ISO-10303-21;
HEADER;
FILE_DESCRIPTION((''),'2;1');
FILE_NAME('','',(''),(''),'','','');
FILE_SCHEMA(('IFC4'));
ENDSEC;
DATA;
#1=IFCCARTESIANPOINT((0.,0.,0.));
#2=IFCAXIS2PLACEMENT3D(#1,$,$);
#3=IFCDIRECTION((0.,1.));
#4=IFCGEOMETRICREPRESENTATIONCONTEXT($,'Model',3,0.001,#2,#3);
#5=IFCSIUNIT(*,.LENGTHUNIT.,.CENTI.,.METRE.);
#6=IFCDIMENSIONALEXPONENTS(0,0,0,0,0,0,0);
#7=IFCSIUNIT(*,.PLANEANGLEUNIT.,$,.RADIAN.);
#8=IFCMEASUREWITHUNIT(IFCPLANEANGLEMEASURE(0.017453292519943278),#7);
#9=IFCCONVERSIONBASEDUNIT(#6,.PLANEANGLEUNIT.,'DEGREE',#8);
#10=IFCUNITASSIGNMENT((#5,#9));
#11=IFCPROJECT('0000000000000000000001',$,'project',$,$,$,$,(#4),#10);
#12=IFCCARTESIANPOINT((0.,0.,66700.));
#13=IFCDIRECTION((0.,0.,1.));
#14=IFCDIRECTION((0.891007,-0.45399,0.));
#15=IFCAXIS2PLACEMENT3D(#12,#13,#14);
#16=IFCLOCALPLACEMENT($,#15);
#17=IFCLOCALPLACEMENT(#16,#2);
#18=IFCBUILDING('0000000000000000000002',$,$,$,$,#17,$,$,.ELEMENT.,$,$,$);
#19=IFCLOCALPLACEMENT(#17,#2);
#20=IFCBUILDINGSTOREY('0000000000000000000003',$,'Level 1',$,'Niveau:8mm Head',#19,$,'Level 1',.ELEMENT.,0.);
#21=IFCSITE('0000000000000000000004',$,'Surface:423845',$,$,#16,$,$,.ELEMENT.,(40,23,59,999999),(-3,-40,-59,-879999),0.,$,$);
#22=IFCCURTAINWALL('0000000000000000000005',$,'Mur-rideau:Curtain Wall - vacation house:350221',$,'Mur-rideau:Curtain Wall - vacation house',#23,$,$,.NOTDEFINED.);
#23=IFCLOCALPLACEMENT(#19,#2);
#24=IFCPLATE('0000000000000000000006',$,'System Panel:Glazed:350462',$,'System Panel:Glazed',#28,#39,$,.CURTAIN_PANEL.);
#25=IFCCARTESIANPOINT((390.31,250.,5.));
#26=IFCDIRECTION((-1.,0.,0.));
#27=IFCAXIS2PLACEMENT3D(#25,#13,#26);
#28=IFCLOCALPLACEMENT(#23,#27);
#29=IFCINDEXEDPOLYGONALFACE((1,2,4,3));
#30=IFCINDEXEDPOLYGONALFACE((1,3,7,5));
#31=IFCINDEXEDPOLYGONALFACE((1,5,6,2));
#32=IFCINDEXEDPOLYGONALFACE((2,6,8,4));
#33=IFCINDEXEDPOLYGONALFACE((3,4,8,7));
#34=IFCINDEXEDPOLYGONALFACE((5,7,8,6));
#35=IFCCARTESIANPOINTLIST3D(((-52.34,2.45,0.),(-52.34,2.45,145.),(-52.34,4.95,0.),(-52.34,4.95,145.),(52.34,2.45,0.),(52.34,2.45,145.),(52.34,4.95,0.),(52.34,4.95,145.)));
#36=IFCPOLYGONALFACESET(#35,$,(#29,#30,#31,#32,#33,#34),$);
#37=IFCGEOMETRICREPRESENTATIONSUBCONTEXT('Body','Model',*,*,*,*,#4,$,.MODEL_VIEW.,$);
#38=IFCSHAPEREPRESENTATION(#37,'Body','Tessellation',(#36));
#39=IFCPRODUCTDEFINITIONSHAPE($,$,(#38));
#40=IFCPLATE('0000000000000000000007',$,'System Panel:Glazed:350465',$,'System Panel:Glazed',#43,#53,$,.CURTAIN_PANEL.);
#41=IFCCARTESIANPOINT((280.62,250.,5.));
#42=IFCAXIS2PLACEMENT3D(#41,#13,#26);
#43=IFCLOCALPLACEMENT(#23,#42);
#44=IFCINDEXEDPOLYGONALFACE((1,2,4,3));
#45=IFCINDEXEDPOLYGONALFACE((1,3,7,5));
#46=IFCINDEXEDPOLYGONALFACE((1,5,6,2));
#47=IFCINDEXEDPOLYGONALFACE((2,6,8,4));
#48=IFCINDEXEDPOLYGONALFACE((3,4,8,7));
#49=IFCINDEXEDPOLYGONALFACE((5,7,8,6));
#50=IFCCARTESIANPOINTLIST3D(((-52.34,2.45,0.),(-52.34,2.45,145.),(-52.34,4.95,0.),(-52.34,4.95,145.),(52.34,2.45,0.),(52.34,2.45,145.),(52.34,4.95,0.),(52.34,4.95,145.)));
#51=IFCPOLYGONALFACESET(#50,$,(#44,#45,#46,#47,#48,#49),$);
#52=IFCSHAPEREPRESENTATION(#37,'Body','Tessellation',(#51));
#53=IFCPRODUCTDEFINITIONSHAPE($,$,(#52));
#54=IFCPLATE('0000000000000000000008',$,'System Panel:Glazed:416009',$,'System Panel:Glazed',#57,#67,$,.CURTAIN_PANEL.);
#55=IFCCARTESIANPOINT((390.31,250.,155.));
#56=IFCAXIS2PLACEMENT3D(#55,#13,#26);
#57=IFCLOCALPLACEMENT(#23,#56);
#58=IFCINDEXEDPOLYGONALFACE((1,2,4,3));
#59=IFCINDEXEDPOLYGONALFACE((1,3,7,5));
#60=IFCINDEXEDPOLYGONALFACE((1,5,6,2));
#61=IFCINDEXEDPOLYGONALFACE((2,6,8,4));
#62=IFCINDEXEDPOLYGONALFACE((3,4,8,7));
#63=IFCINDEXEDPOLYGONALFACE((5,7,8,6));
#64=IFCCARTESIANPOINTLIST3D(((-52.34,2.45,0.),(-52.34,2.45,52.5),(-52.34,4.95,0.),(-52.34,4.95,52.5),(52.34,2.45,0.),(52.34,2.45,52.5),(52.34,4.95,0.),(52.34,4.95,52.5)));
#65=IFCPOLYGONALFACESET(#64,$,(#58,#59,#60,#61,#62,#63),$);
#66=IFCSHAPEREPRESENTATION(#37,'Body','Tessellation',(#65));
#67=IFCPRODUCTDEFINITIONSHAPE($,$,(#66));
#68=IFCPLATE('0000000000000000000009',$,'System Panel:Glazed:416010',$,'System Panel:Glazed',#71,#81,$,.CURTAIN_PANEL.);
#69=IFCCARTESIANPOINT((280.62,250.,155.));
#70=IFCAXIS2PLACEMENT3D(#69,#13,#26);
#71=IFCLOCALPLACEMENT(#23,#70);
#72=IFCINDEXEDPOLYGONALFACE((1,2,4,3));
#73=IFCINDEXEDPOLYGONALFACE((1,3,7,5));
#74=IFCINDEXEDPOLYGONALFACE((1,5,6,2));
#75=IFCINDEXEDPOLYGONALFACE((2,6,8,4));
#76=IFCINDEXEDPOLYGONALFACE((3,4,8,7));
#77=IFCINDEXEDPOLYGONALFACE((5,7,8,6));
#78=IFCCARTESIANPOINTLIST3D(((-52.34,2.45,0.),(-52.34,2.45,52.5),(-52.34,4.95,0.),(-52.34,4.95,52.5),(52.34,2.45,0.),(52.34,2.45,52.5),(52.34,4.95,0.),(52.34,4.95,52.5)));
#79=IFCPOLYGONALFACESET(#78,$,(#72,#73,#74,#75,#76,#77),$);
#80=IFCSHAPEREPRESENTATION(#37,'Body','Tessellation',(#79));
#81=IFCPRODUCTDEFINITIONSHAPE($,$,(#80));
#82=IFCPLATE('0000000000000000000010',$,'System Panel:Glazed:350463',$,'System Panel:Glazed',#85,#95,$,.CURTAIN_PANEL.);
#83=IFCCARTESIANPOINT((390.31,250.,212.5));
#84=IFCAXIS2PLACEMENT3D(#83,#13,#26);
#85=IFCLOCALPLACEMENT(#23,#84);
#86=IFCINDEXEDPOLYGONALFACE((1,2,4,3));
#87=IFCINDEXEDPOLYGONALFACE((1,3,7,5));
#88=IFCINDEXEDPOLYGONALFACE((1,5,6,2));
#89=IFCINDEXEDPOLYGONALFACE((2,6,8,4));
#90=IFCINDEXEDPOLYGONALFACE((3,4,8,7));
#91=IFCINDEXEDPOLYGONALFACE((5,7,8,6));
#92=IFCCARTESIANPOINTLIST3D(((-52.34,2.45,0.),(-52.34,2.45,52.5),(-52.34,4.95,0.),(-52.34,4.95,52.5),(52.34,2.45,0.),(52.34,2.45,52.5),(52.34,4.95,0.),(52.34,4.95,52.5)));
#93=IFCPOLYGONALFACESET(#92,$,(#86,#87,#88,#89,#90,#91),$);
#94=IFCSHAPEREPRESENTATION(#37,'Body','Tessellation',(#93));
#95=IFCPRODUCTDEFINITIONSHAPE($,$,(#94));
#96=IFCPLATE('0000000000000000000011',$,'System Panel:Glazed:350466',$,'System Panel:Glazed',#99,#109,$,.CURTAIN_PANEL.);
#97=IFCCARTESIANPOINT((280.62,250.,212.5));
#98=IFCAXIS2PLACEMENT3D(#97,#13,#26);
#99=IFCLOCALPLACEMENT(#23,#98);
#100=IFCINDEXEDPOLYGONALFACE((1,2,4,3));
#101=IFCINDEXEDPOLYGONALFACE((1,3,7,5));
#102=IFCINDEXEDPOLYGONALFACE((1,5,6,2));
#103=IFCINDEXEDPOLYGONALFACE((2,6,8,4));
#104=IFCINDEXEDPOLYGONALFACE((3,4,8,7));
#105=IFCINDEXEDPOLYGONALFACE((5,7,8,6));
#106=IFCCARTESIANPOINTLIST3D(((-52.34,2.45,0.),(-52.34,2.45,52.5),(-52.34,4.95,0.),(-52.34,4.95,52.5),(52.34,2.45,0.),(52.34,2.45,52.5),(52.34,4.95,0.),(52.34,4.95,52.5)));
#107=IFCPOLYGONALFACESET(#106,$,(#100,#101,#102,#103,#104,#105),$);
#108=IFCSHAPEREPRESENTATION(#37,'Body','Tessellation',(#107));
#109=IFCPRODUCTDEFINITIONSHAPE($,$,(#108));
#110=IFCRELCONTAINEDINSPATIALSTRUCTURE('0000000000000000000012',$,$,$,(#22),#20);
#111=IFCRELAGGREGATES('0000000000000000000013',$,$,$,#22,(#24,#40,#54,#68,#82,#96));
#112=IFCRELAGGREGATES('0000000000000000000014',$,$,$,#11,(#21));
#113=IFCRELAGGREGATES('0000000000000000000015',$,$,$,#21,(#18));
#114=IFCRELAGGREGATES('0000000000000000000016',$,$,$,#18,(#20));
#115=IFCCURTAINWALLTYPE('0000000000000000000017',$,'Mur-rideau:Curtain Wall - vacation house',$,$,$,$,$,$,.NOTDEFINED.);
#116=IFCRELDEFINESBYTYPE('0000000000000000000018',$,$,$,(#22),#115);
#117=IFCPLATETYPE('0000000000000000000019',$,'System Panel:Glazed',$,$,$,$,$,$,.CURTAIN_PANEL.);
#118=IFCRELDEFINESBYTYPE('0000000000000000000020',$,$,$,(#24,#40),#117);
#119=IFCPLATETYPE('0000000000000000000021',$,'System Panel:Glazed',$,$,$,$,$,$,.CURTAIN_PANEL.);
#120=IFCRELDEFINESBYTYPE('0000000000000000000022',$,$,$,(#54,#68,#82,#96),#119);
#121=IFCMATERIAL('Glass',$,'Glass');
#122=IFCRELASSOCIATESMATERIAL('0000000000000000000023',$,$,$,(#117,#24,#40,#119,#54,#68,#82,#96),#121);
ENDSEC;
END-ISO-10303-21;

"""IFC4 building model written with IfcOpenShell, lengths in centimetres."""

from ifc_helpers import new_model, entity, si_unit, converted_unit, direction, frame, origin, origin_2d_with_axis, place, context, subcontext, project, spatial, rectangle, extrude, source, transform, mapped, material, type_object, type_shapes, element, aggregate, save


model = new_model("IFC4")

# Units and contexts
model_context = context("Model", 3, precision=0.001, world=origin(), true_north=direction((0.0, 1.0)))
body_context = subcontext(model_context, "Body", "Model", "MODEL_VIEW")
ifc_project = project(units=[si_unit("LENGTHUNIT", "METRE", prefix="CENTI"), converted_unit("PLANEANGLEUNIT", "DEGREE", entity("IfcPlaneAngleMeasure", 0.017453292519943278), si_unit("PLANEANGLEUNIT", "RADIAN"), dimensions=[0, 0, 0, 0, 0, 0, 0])], contexts=[model_context])

# Site, building, storey
site_placement = place(None, frame((0.0, 0.0, 66700.0), z_axis=(0.0, 0.0, 1.0), x_axis=(0.891007, -0.45399, 0.0)))
site = spatial("IfcSite", under=ifc_project, at=site_placement, Name="Surface:423845", CompositionType="ELEMENT", RefLatitude=(40, 23, 59, 999999), RefLongitude=(-3, -40, -59, -879999), RefElevation=0.0)
building_placement = place(site_placement, origin())
building = spatial("IfcBuilding", under=site, at=building_placement, CompositionType="ELEMENT")
storey_placement = place(building_placement, origin())
storey = spatial("IfcBuildingStorey", under=building, at=storey_placement, Name="Level 1", ObjectType="Niveau:8mm Head", LongName="Level 1", CompositionType="ELEMENT", Elevation=0.0)

# Curtain wall
curtain_wall_type = type_object("IfcCurtainWallType", Name="Mur-rideau:Curtain Wall - vacation house", PredefinedType="NOTDEFINED")
curtain_wall_placement = place(storey_placement, origin())
curtain_wall = element("IfcCurtainWall", 1, at=curtain_wall_placement, inside=storey, type_object=curtain_wall_type, Name="Mur-rideau:Curtain Wall - vacation house:350221", ObjectType="Mur-rideau:Curtain Wall - vacation house", PredefinedType="NOTDEFINED")

# Plates
ifc_material_1 = material(Name="Glass", Category="Glass")
plate_type_1 = type_object("IfcPlateType", Name="System Panel:Glazed", PredefinedType="CURTAIN_PANEL", material=ifc_material_1)
shared_shape_1 = source(origin(), body_context, "Body", "SweptSolid", [
    extrude(rectangle(XDim=2.5, YDim=104.69, at=origin_2d_with_axis()), frame((0.0, 3.7, 0.0), z_axis=(0.0, 0.0, 1.0), x_axis=(0.0, 1.0, 0.0)), (0.0, 0.0, 1.0), 145.0),
])
type_shapes(plate_type_1, [shared_shape_1])
plate_1_placement = place(curtain_wall_placement, frame((390.31, 250.0, 5.0), z_axis=(0.0, 0.0, 1.0), x_axis=(-1.0, 0.0, 0.0)))
plate_1 = element("IfcPlate", 2, at=plate_1_placement, type_object=plate_type_1, material=ifc_material_1, Name="System Panel:Glazed:350462", ObjectType="System Panel:Glazed", PredefinedType="CURTAIN_PANEL", context=body_context, shape_type="MappedRepresentation", body=[
    mapped(shared_shape_1, transform((0.0, 0.0, 0.0), scale=1.0)),
])
plate_2_placement = place(curtain_wall_placement, frame((280.62, 250.0, 5.0), z_axis=(0.0, 0.0, 1.0), x_axis=(-1.0, 0.0, 0.0)))
plate_2 = element("IfcPlate", 3, at=plate_2_placement, type_object=plate_type_1, material=ifc_material_1, Name="System Panel:Glazed:350465", ObjectType="System Panel:Glazed", PredefinedType="CURTAIN_PANEL", context=body_context, shape_type="MappedRepresentation", body=[
    mapped(shared_shape_1, transform((0.0, 0.0, 0.0), scale=1.0)),
])
plate_type_2 = type_object("IfcPlateType", Name="System Panel:Glazed", PredefinedType="CURTAIN_PANEL", material=ifc_material_1)
shared_shape_2 = source(origin(), body_context, "Body", "SweptSolid", [
    extrude(rectangle(XDim=2.5, YDim=104.69, at=origin_2d_with_axis()), frame((0.0, 3.7, 0.0), z_axis=(0.0, 0.0, 1.0), x_axis=(0.0, 1.0, 0.0)), (0.0, 0.0, 1.0), 52.5),
])
type_shapes(plate_type_2, [shared_shape_2])
plate_3_placement = place(curtain_wall_placement, frame((390.31, 250.0, 155.0), z_axis=(0.0, 0.0, 1.0), x_axis=(-1.0, 0.0, 0.0)))
plate_3 = element("IfcPlate", 4, at=plate_3_placement, type_object=plate_type_2, material=ifc_material_1, Name="System Panel:Glazed:416009", ObjectType="System Panel:Glazed", PredefinedType="CURTAIN_PANEL", context=body_context, shape_type="MappedRepresentation", body=[
    mapped(shared_shape_2, transform((0.0, 0.0, 0.0), scale=1.0)),
])
plate_4_placement = place(curtain_wall_placement, frame((280.62, 250.0, 155.0), z_axis=(0.0, 0.0, 1.0), x_axis=(-1.0, 0.0, 0.0)))
plate_4 = element("IfcPlate", 5, at=plate_4_placement, type_object=plate_type_2, material=ifc_material_1, Name="System Panel:Glazed:416010", ObjectType="System Panel:Glazed", PredefinedType="CURTAIN_PANEL", context=body_context, shape_type="MappedRepresentation", body=[
    mapped(shared_shape_2, transform((0.0, 0.0, 0.0), scale=1.0)),
])
plate_5_placement = place(curtain_wall_placement, frame((390.31, 250.0, 212.5), z_axis=(0.0, 0.0, 1.0), x_axis=(-1.0, 0.0, 0.0)))
plate_5 = element("IfcPlate", 6, at=plate_5_placement, type_object=plate_type_2, material=ifc_material_1, Name="System Panel:Glazed:350463", ObjectType="System Panel:Glazed", PredefinedType="CURTAIN_PANEL", context=body_context, shape_type="MappedRepresentation", body=[
    mapped(shared_shape_2, transform((0.0, 0.0, 0.0), scale=1.0)),
])
plate_6_placement = place(curtain_wall_placement, frame((280.62, 250.0, 212.5), z_axis=(0.0, 0.0, 1.0), x_axis=(-1.0, 0.0, 0.0)))
plate_6 = element("IfcPlate", 7, at=plate_6_placement, type_object=plate_type_2, material=ifc_material_1, Name="System Panel:Glazed:350466", ObjectType="System Panel:Glazed", PredefinedType="CURTAIN_PANEL", context=body_context, shape_type="MappedRepresentation", body=[
    mapped(shared_shape_2, transform((0.0, 0.0, 0.0), scale=1.0)),
])
aggregate(curtain_wall, [plate_1, plate_2, plate_3, plate_4, plate_5, plate_6])

save(model, "model.ifc")
